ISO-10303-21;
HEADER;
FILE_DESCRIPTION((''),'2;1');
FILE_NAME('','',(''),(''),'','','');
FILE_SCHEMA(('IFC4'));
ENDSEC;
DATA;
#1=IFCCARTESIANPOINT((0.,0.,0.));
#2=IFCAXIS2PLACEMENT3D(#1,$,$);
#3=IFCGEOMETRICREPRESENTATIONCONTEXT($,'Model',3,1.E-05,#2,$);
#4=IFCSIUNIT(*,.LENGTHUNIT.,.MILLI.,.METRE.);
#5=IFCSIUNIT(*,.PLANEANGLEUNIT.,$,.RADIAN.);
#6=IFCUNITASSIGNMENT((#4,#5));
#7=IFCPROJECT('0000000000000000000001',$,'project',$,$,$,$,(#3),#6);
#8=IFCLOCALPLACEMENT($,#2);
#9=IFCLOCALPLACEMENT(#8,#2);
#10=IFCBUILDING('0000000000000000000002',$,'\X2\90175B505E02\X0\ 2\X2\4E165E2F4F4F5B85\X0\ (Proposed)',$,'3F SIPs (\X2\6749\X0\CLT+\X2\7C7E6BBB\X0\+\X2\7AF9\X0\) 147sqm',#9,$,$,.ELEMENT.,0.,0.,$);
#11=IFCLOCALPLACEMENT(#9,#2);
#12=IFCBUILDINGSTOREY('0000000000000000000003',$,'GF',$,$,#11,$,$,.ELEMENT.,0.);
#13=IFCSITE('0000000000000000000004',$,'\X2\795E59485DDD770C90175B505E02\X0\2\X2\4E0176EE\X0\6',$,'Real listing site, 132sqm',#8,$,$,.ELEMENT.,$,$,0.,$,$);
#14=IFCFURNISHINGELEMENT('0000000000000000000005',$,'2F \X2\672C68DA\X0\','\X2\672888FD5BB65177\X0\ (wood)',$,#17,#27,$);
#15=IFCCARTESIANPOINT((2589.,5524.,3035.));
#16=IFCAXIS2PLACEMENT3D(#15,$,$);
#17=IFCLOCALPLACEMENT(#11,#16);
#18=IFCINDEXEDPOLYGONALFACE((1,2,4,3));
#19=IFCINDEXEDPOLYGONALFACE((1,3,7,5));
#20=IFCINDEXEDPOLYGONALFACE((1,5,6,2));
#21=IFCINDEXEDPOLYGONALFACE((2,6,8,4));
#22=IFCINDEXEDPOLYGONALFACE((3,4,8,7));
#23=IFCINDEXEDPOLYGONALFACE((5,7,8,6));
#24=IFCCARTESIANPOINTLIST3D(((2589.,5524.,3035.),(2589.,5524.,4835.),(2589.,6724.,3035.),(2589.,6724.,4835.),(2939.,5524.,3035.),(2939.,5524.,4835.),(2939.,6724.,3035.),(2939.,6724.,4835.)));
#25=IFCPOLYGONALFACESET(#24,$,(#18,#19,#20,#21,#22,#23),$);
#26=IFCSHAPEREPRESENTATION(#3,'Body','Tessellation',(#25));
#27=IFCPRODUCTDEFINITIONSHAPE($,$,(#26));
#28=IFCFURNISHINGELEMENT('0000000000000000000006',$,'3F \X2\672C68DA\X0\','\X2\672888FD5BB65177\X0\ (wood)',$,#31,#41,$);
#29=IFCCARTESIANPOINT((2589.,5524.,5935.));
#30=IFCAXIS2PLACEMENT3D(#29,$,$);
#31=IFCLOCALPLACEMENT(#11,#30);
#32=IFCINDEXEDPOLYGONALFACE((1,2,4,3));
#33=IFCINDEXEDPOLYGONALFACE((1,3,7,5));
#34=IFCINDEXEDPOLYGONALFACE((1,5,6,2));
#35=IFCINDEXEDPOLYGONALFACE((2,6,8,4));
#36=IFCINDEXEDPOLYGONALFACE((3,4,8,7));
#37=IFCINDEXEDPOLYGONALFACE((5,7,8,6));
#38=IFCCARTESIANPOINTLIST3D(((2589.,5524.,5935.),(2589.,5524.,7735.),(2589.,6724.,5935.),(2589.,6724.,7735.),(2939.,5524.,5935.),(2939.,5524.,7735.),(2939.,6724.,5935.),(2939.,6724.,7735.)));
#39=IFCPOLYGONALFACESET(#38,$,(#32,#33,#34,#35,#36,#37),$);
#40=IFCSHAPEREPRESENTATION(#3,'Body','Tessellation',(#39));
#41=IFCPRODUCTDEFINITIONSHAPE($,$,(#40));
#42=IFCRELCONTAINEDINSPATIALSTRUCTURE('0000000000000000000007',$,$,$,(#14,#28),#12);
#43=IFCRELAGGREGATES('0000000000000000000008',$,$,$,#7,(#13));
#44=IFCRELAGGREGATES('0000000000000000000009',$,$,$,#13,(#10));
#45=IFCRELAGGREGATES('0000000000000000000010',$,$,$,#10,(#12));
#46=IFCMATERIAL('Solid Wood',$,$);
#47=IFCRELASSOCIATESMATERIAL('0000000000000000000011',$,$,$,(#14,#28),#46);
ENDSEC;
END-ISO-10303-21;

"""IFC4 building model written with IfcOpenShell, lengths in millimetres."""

from ifc_helpers import new_model, si_unit, frame, frame_2d, origin, place, context, project, spatial, rectangle, extrude, material, element, save


model = new_model("IFC4")

# Units and contexts
model_context = context("Model", 3, precision=1e-05, world=origin())
ifc_project = project(units=[si_unit("LENGTHUNIT", "METRE", prefix="MILLI"), si_unit("PLANEANGLEUNIT", "RADIAN")], contexts=[model_context])

# Site, building, storey
site_placement = place(None, origin())
site = spatial("IfcSite", under=ifc_project, at=site_placement, Name="神奈川県逗子市2丁目6", ObjectType="Real listing site, 132sqm", CompositionType="ELEMENT", RefElevation=0.0)
building_placement = place(site_placement, origin())
building = spatial("IfcBuilding", under=site, at=building_placement, Name="逗子市 2世帯住宅 (Proposed)", ObjectType="3F SIPs (杉CLT+籾殻+竹) 147sqm", CompositionType="ELEMENT", ElevationOfRefHeight=0.0, ElevationOfTerrain=0.0)
storey_placement = place(building_placement, origin())
storey = spatial("IfcBuildingStorey", under=building, at=storey_placement, Name="GF", CompositionType="ELEMENT", Elevation=0.0)

# Shared definitions
ifc_material_1 = material(Name="Solid Wood")

# Furnishing elements
furnishing_1_placement = place(storey_placement, frame((2589.0, 5524.0, 3035.0)))
element("IfcFurnishingElement", 1, at=furnishing_1_placement, inside=storey, material=ifc_material_1, Name="2F 本棚", Description="木製家具 (wood)", context=model_context, shape_type="SweptSolid", body=[
    extrude(rectangle(XDim=350.0, YDim=1200.0, at=frame_2d((175.0, 600.0))), frame((2589.0, 5524.0, 3035.0)), (0.0, 0.0, 1.0), 1800.0),
])
furnishing_2_placement = place(storey_placement, frame((2589.0, 5524.0, 5935.0)))
element("IfcFurnishingElement", 2, at=furnishing_2_placement, inside=storey, material=ifc_material_1, Name="3F 本棚", Description="木製家具 (wood)", context=model_context, shape_type="SweptSolid", body=[
    extrude(rectangle(XDim=350.0, YDim=1200.0, at=frame_2d((175.0, 600.0))), frame((2589.0, 5524.0, 5935.0)), (0.0, 0.0, 1.0), 1800.0),
])

save(model, "model.ifc")
